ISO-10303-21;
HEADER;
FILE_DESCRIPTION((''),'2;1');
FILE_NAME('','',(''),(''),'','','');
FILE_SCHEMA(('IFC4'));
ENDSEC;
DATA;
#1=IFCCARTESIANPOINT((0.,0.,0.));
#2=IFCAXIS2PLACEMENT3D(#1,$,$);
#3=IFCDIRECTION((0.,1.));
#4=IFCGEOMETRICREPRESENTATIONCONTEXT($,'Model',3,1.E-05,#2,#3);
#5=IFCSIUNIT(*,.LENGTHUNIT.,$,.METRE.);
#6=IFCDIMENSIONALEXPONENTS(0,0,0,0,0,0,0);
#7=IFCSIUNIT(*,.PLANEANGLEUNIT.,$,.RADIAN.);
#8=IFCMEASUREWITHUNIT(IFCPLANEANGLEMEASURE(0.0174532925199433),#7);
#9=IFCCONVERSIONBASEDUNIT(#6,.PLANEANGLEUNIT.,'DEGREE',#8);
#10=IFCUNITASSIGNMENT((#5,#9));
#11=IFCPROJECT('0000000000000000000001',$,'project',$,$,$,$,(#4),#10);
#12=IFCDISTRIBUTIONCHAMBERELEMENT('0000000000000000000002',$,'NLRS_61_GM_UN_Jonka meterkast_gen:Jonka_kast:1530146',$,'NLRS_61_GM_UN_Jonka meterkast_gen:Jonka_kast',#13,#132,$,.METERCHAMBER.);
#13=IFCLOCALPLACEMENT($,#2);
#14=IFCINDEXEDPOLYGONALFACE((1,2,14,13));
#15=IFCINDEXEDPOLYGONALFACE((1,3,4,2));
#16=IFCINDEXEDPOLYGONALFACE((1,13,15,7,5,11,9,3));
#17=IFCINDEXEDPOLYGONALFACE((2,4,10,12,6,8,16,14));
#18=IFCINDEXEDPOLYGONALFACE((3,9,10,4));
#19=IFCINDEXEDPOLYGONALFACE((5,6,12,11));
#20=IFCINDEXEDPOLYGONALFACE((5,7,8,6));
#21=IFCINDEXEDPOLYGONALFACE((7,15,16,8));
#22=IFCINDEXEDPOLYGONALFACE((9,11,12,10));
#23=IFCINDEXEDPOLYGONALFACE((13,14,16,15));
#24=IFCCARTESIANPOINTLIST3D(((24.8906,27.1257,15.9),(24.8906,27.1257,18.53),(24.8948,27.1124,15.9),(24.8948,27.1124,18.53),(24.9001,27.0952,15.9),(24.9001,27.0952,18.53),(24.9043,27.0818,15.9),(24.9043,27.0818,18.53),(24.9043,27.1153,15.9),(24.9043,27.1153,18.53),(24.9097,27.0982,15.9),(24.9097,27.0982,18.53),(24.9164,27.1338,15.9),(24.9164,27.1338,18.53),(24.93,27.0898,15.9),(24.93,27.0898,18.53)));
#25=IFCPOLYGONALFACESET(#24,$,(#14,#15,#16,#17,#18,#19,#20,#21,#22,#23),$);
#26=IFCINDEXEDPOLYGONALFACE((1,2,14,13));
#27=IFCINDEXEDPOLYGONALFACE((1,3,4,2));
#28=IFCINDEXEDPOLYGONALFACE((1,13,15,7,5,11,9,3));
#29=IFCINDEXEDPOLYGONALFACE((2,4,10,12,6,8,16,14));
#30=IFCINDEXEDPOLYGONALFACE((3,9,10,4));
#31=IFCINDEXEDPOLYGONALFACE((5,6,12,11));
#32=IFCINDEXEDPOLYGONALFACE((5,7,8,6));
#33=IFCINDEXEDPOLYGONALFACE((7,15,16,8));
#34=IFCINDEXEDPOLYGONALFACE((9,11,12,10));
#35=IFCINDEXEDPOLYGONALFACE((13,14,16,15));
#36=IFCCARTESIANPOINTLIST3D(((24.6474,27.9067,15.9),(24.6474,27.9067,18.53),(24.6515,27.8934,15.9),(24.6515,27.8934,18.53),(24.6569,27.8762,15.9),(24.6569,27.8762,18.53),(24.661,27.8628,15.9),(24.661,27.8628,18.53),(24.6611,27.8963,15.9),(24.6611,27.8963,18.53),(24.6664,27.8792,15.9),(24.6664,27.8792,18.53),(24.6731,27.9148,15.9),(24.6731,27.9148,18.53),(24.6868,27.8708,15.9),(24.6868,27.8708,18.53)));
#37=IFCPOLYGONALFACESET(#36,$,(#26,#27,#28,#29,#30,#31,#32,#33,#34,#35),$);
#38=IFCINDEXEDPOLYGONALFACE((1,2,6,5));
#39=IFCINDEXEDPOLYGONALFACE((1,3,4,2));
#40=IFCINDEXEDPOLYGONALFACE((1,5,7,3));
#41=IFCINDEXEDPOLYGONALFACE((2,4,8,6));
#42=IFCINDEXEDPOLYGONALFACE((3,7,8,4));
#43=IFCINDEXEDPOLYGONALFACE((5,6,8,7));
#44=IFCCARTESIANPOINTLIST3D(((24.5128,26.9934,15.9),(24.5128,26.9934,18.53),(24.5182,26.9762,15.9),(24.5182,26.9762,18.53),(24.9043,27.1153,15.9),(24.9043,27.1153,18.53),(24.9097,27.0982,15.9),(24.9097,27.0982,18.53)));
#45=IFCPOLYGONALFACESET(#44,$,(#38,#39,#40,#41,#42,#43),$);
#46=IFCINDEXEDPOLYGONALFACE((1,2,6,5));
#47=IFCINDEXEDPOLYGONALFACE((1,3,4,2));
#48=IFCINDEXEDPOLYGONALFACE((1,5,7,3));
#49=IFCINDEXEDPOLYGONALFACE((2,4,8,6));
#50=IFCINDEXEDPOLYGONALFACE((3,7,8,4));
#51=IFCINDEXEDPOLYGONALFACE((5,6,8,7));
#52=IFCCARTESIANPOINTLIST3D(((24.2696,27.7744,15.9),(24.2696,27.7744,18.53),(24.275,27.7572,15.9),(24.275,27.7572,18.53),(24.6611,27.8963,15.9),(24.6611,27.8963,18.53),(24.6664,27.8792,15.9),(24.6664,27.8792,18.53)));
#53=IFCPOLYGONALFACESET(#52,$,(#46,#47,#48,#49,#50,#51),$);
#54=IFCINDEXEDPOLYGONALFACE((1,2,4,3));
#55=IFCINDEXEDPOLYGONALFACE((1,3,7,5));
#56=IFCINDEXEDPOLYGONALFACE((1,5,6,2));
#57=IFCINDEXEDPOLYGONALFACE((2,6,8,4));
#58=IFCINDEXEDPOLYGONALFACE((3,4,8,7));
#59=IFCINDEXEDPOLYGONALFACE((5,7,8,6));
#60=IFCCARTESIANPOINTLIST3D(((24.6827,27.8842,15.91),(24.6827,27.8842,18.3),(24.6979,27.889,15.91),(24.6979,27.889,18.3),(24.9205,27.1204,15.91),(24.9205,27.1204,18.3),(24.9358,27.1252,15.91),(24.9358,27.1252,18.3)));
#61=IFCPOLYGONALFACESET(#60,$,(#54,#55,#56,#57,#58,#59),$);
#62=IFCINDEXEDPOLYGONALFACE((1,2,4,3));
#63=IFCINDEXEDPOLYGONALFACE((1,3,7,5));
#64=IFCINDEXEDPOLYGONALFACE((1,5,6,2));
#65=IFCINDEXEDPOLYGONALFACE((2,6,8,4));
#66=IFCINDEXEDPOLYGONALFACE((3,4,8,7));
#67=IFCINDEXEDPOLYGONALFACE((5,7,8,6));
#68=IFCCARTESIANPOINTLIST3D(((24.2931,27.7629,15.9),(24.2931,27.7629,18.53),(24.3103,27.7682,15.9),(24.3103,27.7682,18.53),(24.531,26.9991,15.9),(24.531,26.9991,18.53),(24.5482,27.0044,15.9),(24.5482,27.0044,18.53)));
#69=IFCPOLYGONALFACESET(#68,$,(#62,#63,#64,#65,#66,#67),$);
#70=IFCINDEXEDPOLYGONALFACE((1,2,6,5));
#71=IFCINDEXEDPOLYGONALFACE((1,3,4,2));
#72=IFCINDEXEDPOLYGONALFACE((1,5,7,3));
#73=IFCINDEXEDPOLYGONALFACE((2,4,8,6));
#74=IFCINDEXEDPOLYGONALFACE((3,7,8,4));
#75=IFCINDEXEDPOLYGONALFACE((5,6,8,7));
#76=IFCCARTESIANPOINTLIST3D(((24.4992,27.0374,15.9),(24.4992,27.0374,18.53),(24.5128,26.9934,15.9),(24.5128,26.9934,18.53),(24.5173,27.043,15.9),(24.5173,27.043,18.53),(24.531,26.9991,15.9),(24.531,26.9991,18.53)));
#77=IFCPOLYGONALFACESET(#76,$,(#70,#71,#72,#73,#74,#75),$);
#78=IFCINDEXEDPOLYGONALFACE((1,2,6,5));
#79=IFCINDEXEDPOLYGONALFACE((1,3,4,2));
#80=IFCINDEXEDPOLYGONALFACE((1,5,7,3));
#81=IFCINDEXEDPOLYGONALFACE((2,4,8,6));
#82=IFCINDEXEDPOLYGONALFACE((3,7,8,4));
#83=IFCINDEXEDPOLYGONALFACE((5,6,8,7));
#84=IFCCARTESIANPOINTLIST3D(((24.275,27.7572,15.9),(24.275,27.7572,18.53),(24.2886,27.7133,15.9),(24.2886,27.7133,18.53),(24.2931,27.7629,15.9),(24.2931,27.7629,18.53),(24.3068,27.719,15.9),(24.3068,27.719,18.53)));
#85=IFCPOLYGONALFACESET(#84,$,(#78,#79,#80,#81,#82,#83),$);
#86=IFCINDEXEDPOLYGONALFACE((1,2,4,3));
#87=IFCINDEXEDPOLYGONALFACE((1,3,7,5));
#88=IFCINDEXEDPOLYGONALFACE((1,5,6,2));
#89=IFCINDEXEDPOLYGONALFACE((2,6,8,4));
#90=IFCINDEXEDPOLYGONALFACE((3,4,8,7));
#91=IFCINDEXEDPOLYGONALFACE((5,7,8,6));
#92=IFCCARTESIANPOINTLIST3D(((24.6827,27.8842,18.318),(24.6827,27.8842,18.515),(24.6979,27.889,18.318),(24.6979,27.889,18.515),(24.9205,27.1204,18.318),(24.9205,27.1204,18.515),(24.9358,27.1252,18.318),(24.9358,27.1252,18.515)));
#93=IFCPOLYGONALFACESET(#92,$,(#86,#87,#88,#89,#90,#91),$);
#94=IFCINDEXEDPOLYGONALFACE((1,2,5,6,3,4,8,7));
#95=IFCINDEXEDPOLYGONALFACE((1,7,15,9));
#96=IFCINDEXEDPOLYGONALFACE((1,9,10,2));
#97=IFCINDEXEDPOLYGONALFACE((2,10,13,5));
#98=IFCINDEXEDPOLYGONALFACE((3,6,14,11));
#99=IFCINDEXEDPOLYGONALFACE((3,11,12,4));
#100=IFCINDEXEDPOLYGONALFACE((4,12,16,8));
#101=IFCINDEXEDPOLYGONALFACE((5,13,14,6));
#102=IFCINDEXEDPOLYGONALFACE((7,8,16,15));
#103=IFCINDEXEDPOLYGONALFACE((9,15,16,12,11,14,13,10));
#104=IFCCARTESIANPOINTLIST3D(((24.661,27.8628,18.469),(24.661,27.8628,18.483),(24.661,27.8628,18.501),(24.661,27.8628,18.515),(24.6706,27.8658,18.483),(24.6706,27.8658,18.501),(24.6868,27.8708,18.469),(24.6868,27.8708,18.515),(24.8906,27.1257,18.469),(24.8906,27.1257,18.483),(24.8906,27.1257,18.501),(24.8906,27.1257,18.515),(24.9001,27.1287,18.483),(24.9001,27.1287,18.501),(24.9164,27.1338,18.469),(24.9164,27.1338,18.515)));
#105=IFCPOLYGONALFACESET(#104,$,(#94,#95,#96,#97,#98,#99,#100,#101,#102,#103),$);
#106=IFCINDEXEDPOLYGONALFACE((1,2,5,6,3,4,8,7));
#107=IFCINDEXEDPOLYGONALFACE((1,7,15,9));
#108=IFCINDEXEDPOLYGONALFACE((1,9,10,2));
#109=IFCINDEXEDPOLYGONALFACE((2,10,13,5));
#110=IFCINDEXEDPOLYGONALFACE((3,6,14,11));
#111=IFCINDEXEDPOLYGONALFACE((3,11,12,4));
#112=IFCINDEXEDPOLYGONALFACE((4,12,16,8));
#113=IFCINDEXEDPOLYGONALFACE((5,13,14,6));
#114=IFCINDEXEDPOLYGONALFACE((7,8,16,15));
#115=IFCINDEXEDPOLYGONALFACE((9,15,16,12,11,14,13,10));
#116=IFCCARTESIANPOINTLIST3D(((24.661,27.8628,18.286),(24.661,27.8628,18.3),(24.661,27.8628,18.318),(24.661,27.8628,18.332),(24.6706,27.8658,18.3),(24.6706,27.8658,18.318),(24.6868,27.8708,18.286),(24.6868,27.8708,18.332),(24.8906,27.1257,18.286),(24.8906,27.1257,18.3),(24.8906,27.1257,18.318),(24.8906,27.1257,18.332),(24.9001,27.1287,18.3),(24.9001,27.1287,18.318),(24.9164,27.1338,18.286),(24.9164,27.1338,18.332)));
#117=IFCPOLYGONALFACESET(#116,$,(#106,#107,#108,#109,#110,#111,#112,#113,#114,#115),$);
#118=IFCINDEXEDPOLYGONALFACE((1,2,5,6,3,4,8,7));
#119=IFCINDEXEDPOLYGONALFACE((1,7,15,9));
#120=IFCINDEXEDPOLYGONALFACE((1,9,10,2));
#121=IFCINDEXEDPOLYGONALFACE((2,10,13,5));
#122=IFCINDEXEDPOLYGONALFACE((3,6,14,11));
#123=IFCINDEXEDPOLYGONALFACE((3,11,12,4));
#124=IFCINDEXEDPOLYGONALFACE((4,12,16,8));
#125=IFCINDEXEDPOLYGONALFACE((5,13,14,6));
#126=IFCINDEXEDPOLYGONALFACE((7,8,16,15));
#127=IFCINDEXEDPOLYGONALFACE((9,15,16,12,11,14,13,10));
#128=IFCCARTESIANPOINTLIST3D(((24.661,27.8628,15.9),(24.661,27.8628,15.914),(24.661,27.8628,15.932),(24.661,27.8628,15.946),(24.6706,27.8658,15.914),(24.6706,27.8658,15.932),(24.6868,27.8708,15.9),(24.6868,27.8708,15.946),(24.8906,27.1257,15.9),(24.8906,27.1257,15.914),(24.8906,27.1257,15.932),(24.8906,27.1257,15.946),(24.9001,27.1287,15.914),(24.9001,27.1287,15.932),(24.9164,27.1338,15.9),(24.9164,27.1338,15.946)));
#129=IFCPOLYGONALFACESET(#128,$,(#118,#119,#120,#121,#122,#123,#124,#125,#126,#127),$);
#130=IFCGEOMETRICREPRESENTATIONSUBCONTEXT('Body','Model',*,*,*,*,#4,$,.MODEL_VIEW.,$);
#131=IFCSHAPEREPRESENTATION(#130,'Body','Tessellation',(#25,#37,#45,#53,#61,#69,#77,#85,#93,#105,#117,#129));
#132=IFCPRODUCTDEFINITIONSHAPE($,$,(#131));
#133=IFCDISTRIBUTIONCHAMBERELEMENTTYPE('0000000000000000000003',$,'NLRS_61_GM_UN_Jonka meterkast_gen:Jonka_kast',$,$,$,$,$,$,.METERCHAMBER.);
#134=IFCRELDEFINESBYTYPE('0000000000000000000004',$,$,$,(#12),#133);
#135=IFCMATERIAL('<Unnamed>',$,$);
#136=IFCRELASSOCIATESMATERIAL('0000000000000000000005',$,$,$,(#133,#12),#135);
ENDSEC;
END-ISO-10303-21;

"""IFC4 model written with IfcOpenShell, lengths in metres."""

from ifc_helpers import new_model, entity, si_unit, converted_unit, direction, frame, origin, place, context, subcontext, project, indexed_curve, outline, extrude, source, transform, mapped, material, type_object, type_shapes, element, save


model = new_model("IFC4")

# Units and contexts
model_context = context("Model", 3, precision=1e-05, world=origin(), true_north=direction((0.0, 1.0)))
body_context = subcontext(model_context, "Body", "Model", "MODEL_VIEW")
ifc_project = project(units=[si_unit("LENGTHUNIT", "METRE"), converted_unit("PLANEANGLEUNIT", "DEGREE", entity("IfcPlaneAngleMeasure", 0.0174532925199433), si_unit("PLANEANGLEUNIT", "RADIAN"), dimensions=[0, 0, 0, 0, 0, 0, 0])], contexts=[model_context])

# Distribution chamber element
ifc_material = material(Name="<Unnamed>")
distribution_chamber_element_type = type_object("IfcDistributionChamberElementType", Name="NLRS_61_GM_UN_Jonka meterkast_gen:Jonka_kast", PredefinedType="METERCHAMBER", material=ifc_material)
shared_shape_1 = source(origin(), body_context, "Body", "SweptSolid", [
    extrude(outline(indexed_curve([(-0.0093, -0.023), (0.0178, -0.023), (0.0178, 0.023), (-0.0093, 0.023), (-0.0093, 0.009), (0.0007, 0.009), (0.0007, -0.009), (-0.0093, -0.009), (-0.0093, -0.023)], self_intersect=False)), frame((-0.409, -0.4092, 0.0), z_axis=(0.0, 0.0, 1.0), x_axis=(0.0, -1.0, 0.0)), (0.0, 0.0, 1.0), 2.63),
    extrude(outline(indexed_curve([(-0.0093, -0.023), (0.0178, -0.023), (0.0178, 0.023), (-0.0093, 0.023), (-0.0093, 0.009), (0.0007, 0.009), (0.0007, -0.009), (-0.0093, -0.009), (-0.0093, -0.023)], self_intersect=False)), frame((0.409, -0.4092, 0.0), z_axis=(0.0, 0.0, 1.0), x_axis=(0.0, -1.0, 0.0)), (0.0, 0.0, 1.0), 2.63),
    extrude(outline(indexed_curve([(-0.205, -0.009), (0.205, -0.009), (0.205, 0.009), (-0.205, 0.009), (-0.205, -0.009)], self_intersect=False)), frame((-0.409, -0.205, 0.0), z_axis=(0.0, 0.0, 1.0), x_axis=(0.0, -1.0, 0.0)), (0.0, 0.0, 1.0), 2.63),
    extrude(outline(indexed_curve([(-0.205, -0.009), (0.205, -0.009), (0.205, 0.009), (-0.205, 0.009), (-0.205, -0.009)], self_intersect=False)), frame((0.409, -0.205, 0.0), z_axis=(0.0, 0.0, 1.0), x_axis=(0.0, -1.0, 0.0)), (0.0, 0.0, 1.0), 2.63),
    extrude(outline(indexed_curve([(-0.4, -0.008), (0.4, -0.008), (0.4, 0.008), (-0.4, 0.008), (-0.4, -0.008)], self_intersect=False)), frame((0.0, -0.435, 0.01), z_axis=(0.0, 0.0, 1.0), x_axis=(-1.0, 0.0, 0.0)), (0.0, 0.0, 1.0), 2.39),
    extrude(outline(indexed_curve([(-0.4, -0.009), (0.4, -0.009), (0.4, 0.009), (-0.4, 0.009), (-0.4, -0.009)], self_intersect=False)), frame((0.0, -0.028, 0.0), z_axis=(0.0, 0.0, 1.0), x_axis=(-1.0, 0.0, 0.0)), (0.0, 0.0, 1.0), 2.63),
    extrude(outline(indexed_curve([(-0.023, -0.0095), (0.023, -0.0095), (0.023, 0.0095), (-0.023, 0.0095), (-0.023, -0.0095)], self_intersect=False)), frame((-0.377, -0.0095, 0.0), z_axis=(0.0, 0.0, 1.0), x_axis=(-1.0, 0.0, 0.0)), (0.0, 0.0, 1.0), 2.63),
    extrude(outline(indexed_curve([(-0.023, -0.0095), (0.023, -0.0095), (0.023, 0.0095), (-0.023, 0.0095), (-0.023, -0.0095)], self_intersect=False)), frame((0.377, -0.0095, 0.0), z_axis=(0.0, 0.0, 1.0), x_axis=(-1.0, 0.0, 0.0)), (0.0, 0.0, 1.0), 2.63),
    extrude(outline(indexed_curve([(-0.4, -0.008), (0.4, -0.008), (0.4, 0.008), (-0.4, 0.008), (-0.4, -0.008)], self_intersect=False)), frame((0.0, -0.435, 2.418), z_axis=(0.0, 0.0, 1.0), x_axis=(-1.0, 0.0, 0.0)), (0.0, 0.0, 1.0), 0.197),
    extrude(outline(indexed_curve([(-0.023, -0.0178), (0.023, -0.0178), (0.023, 0.0093), (0.009, 0.0093), (0.009, -0.0007), (-0.009, -0.0007), (-0.009, 0.0093), (-0.023, 0.0093), (-0.023, -0.0178)], self_intersect=False)), frame((-0.386, -0.4092, 2.592), z_axis=(1.0, 0.0, 0.0), x_axis=(0.0, 0.0, -1.0)), (0.0, 0.0, 1.0), 0.772),
    extrude(outline(indexed_curve([(-0.023, -0.0178), (0.023, -0.0178), (0.023, 0.0093), (0.009, 0.0093), (0.009, -0.0007), (-0.009, -0.0007), (-0.009, 0.0093), (-0.023, 0.0093), (-0.023, -0.0178)], self_intersect=False)), frame((-0.386, -0.4092, 2.409), z_axis=(1.0, 0.0, 0.0), x_axis=(0.0, 0.0, -1.0)), (0.0, 0.0, 1.0), 0.772),
    extrude(outline(indexed_curve([(-0.023, -0.0178), (0.023, -0.0178), (0.023, 0.0093), (0.009, 0.0093), (0.009, -0.0007), (-0.009, -0.0007), (-0.009, 0.0093), (-0.023, 0.0093), (-0.023, -0.0178)], self_intersect=False)), frame((-0.386, -0.4092, 0.023), z_axis=(1.0, 0.0, 0.0), x_axis=(0.0, 0.0, -1.0)), (0.0, 0.0, 1.0), 0.772),
])
type_shapes(distribution_chamber_element_type, [shared_shape_1])
placement_1 = place(None, frame((13.1348, 11.9886, 0.0), z_axis=(0.0, 0.0, 1.0), x_axis=(0.954771, 0.297342, 0.0)))
placement_2 = place(placement_1, origin())
placement_3 = place(placement_2, frame((0.0, 0.0, 15.9)))
placement_4 = place(placement_3, origin())
distribution_chamber_element_1_placement = place(placement_4, frame((15.325, 11.343, 0.0), z_axis=(0.0, 0.0, 1.0), x_axis=(0.0, 1.0, 0.0)))
element("IfcDistributionChamberElement", 1, at=distribution_chamber_element_1_placement, type_object=distribution_chamber_element_type, material=ifc_material, Name="NLRS_61_GM_UN_Jonka meterkast_gen:Jonka_kast:1530146", ObjectType="NLRS_61_GM_UN_Jonka meterkast_gen:Jonka_kast", PredefinedType="METERCHAMBER", context=body_context, shape_type="MappedRepresentation", body=[
    mapped(shared_shape_1, transform((0.0, 0.0, 0.0), scale=1.0)),
])

save(model, "model.ifc")
